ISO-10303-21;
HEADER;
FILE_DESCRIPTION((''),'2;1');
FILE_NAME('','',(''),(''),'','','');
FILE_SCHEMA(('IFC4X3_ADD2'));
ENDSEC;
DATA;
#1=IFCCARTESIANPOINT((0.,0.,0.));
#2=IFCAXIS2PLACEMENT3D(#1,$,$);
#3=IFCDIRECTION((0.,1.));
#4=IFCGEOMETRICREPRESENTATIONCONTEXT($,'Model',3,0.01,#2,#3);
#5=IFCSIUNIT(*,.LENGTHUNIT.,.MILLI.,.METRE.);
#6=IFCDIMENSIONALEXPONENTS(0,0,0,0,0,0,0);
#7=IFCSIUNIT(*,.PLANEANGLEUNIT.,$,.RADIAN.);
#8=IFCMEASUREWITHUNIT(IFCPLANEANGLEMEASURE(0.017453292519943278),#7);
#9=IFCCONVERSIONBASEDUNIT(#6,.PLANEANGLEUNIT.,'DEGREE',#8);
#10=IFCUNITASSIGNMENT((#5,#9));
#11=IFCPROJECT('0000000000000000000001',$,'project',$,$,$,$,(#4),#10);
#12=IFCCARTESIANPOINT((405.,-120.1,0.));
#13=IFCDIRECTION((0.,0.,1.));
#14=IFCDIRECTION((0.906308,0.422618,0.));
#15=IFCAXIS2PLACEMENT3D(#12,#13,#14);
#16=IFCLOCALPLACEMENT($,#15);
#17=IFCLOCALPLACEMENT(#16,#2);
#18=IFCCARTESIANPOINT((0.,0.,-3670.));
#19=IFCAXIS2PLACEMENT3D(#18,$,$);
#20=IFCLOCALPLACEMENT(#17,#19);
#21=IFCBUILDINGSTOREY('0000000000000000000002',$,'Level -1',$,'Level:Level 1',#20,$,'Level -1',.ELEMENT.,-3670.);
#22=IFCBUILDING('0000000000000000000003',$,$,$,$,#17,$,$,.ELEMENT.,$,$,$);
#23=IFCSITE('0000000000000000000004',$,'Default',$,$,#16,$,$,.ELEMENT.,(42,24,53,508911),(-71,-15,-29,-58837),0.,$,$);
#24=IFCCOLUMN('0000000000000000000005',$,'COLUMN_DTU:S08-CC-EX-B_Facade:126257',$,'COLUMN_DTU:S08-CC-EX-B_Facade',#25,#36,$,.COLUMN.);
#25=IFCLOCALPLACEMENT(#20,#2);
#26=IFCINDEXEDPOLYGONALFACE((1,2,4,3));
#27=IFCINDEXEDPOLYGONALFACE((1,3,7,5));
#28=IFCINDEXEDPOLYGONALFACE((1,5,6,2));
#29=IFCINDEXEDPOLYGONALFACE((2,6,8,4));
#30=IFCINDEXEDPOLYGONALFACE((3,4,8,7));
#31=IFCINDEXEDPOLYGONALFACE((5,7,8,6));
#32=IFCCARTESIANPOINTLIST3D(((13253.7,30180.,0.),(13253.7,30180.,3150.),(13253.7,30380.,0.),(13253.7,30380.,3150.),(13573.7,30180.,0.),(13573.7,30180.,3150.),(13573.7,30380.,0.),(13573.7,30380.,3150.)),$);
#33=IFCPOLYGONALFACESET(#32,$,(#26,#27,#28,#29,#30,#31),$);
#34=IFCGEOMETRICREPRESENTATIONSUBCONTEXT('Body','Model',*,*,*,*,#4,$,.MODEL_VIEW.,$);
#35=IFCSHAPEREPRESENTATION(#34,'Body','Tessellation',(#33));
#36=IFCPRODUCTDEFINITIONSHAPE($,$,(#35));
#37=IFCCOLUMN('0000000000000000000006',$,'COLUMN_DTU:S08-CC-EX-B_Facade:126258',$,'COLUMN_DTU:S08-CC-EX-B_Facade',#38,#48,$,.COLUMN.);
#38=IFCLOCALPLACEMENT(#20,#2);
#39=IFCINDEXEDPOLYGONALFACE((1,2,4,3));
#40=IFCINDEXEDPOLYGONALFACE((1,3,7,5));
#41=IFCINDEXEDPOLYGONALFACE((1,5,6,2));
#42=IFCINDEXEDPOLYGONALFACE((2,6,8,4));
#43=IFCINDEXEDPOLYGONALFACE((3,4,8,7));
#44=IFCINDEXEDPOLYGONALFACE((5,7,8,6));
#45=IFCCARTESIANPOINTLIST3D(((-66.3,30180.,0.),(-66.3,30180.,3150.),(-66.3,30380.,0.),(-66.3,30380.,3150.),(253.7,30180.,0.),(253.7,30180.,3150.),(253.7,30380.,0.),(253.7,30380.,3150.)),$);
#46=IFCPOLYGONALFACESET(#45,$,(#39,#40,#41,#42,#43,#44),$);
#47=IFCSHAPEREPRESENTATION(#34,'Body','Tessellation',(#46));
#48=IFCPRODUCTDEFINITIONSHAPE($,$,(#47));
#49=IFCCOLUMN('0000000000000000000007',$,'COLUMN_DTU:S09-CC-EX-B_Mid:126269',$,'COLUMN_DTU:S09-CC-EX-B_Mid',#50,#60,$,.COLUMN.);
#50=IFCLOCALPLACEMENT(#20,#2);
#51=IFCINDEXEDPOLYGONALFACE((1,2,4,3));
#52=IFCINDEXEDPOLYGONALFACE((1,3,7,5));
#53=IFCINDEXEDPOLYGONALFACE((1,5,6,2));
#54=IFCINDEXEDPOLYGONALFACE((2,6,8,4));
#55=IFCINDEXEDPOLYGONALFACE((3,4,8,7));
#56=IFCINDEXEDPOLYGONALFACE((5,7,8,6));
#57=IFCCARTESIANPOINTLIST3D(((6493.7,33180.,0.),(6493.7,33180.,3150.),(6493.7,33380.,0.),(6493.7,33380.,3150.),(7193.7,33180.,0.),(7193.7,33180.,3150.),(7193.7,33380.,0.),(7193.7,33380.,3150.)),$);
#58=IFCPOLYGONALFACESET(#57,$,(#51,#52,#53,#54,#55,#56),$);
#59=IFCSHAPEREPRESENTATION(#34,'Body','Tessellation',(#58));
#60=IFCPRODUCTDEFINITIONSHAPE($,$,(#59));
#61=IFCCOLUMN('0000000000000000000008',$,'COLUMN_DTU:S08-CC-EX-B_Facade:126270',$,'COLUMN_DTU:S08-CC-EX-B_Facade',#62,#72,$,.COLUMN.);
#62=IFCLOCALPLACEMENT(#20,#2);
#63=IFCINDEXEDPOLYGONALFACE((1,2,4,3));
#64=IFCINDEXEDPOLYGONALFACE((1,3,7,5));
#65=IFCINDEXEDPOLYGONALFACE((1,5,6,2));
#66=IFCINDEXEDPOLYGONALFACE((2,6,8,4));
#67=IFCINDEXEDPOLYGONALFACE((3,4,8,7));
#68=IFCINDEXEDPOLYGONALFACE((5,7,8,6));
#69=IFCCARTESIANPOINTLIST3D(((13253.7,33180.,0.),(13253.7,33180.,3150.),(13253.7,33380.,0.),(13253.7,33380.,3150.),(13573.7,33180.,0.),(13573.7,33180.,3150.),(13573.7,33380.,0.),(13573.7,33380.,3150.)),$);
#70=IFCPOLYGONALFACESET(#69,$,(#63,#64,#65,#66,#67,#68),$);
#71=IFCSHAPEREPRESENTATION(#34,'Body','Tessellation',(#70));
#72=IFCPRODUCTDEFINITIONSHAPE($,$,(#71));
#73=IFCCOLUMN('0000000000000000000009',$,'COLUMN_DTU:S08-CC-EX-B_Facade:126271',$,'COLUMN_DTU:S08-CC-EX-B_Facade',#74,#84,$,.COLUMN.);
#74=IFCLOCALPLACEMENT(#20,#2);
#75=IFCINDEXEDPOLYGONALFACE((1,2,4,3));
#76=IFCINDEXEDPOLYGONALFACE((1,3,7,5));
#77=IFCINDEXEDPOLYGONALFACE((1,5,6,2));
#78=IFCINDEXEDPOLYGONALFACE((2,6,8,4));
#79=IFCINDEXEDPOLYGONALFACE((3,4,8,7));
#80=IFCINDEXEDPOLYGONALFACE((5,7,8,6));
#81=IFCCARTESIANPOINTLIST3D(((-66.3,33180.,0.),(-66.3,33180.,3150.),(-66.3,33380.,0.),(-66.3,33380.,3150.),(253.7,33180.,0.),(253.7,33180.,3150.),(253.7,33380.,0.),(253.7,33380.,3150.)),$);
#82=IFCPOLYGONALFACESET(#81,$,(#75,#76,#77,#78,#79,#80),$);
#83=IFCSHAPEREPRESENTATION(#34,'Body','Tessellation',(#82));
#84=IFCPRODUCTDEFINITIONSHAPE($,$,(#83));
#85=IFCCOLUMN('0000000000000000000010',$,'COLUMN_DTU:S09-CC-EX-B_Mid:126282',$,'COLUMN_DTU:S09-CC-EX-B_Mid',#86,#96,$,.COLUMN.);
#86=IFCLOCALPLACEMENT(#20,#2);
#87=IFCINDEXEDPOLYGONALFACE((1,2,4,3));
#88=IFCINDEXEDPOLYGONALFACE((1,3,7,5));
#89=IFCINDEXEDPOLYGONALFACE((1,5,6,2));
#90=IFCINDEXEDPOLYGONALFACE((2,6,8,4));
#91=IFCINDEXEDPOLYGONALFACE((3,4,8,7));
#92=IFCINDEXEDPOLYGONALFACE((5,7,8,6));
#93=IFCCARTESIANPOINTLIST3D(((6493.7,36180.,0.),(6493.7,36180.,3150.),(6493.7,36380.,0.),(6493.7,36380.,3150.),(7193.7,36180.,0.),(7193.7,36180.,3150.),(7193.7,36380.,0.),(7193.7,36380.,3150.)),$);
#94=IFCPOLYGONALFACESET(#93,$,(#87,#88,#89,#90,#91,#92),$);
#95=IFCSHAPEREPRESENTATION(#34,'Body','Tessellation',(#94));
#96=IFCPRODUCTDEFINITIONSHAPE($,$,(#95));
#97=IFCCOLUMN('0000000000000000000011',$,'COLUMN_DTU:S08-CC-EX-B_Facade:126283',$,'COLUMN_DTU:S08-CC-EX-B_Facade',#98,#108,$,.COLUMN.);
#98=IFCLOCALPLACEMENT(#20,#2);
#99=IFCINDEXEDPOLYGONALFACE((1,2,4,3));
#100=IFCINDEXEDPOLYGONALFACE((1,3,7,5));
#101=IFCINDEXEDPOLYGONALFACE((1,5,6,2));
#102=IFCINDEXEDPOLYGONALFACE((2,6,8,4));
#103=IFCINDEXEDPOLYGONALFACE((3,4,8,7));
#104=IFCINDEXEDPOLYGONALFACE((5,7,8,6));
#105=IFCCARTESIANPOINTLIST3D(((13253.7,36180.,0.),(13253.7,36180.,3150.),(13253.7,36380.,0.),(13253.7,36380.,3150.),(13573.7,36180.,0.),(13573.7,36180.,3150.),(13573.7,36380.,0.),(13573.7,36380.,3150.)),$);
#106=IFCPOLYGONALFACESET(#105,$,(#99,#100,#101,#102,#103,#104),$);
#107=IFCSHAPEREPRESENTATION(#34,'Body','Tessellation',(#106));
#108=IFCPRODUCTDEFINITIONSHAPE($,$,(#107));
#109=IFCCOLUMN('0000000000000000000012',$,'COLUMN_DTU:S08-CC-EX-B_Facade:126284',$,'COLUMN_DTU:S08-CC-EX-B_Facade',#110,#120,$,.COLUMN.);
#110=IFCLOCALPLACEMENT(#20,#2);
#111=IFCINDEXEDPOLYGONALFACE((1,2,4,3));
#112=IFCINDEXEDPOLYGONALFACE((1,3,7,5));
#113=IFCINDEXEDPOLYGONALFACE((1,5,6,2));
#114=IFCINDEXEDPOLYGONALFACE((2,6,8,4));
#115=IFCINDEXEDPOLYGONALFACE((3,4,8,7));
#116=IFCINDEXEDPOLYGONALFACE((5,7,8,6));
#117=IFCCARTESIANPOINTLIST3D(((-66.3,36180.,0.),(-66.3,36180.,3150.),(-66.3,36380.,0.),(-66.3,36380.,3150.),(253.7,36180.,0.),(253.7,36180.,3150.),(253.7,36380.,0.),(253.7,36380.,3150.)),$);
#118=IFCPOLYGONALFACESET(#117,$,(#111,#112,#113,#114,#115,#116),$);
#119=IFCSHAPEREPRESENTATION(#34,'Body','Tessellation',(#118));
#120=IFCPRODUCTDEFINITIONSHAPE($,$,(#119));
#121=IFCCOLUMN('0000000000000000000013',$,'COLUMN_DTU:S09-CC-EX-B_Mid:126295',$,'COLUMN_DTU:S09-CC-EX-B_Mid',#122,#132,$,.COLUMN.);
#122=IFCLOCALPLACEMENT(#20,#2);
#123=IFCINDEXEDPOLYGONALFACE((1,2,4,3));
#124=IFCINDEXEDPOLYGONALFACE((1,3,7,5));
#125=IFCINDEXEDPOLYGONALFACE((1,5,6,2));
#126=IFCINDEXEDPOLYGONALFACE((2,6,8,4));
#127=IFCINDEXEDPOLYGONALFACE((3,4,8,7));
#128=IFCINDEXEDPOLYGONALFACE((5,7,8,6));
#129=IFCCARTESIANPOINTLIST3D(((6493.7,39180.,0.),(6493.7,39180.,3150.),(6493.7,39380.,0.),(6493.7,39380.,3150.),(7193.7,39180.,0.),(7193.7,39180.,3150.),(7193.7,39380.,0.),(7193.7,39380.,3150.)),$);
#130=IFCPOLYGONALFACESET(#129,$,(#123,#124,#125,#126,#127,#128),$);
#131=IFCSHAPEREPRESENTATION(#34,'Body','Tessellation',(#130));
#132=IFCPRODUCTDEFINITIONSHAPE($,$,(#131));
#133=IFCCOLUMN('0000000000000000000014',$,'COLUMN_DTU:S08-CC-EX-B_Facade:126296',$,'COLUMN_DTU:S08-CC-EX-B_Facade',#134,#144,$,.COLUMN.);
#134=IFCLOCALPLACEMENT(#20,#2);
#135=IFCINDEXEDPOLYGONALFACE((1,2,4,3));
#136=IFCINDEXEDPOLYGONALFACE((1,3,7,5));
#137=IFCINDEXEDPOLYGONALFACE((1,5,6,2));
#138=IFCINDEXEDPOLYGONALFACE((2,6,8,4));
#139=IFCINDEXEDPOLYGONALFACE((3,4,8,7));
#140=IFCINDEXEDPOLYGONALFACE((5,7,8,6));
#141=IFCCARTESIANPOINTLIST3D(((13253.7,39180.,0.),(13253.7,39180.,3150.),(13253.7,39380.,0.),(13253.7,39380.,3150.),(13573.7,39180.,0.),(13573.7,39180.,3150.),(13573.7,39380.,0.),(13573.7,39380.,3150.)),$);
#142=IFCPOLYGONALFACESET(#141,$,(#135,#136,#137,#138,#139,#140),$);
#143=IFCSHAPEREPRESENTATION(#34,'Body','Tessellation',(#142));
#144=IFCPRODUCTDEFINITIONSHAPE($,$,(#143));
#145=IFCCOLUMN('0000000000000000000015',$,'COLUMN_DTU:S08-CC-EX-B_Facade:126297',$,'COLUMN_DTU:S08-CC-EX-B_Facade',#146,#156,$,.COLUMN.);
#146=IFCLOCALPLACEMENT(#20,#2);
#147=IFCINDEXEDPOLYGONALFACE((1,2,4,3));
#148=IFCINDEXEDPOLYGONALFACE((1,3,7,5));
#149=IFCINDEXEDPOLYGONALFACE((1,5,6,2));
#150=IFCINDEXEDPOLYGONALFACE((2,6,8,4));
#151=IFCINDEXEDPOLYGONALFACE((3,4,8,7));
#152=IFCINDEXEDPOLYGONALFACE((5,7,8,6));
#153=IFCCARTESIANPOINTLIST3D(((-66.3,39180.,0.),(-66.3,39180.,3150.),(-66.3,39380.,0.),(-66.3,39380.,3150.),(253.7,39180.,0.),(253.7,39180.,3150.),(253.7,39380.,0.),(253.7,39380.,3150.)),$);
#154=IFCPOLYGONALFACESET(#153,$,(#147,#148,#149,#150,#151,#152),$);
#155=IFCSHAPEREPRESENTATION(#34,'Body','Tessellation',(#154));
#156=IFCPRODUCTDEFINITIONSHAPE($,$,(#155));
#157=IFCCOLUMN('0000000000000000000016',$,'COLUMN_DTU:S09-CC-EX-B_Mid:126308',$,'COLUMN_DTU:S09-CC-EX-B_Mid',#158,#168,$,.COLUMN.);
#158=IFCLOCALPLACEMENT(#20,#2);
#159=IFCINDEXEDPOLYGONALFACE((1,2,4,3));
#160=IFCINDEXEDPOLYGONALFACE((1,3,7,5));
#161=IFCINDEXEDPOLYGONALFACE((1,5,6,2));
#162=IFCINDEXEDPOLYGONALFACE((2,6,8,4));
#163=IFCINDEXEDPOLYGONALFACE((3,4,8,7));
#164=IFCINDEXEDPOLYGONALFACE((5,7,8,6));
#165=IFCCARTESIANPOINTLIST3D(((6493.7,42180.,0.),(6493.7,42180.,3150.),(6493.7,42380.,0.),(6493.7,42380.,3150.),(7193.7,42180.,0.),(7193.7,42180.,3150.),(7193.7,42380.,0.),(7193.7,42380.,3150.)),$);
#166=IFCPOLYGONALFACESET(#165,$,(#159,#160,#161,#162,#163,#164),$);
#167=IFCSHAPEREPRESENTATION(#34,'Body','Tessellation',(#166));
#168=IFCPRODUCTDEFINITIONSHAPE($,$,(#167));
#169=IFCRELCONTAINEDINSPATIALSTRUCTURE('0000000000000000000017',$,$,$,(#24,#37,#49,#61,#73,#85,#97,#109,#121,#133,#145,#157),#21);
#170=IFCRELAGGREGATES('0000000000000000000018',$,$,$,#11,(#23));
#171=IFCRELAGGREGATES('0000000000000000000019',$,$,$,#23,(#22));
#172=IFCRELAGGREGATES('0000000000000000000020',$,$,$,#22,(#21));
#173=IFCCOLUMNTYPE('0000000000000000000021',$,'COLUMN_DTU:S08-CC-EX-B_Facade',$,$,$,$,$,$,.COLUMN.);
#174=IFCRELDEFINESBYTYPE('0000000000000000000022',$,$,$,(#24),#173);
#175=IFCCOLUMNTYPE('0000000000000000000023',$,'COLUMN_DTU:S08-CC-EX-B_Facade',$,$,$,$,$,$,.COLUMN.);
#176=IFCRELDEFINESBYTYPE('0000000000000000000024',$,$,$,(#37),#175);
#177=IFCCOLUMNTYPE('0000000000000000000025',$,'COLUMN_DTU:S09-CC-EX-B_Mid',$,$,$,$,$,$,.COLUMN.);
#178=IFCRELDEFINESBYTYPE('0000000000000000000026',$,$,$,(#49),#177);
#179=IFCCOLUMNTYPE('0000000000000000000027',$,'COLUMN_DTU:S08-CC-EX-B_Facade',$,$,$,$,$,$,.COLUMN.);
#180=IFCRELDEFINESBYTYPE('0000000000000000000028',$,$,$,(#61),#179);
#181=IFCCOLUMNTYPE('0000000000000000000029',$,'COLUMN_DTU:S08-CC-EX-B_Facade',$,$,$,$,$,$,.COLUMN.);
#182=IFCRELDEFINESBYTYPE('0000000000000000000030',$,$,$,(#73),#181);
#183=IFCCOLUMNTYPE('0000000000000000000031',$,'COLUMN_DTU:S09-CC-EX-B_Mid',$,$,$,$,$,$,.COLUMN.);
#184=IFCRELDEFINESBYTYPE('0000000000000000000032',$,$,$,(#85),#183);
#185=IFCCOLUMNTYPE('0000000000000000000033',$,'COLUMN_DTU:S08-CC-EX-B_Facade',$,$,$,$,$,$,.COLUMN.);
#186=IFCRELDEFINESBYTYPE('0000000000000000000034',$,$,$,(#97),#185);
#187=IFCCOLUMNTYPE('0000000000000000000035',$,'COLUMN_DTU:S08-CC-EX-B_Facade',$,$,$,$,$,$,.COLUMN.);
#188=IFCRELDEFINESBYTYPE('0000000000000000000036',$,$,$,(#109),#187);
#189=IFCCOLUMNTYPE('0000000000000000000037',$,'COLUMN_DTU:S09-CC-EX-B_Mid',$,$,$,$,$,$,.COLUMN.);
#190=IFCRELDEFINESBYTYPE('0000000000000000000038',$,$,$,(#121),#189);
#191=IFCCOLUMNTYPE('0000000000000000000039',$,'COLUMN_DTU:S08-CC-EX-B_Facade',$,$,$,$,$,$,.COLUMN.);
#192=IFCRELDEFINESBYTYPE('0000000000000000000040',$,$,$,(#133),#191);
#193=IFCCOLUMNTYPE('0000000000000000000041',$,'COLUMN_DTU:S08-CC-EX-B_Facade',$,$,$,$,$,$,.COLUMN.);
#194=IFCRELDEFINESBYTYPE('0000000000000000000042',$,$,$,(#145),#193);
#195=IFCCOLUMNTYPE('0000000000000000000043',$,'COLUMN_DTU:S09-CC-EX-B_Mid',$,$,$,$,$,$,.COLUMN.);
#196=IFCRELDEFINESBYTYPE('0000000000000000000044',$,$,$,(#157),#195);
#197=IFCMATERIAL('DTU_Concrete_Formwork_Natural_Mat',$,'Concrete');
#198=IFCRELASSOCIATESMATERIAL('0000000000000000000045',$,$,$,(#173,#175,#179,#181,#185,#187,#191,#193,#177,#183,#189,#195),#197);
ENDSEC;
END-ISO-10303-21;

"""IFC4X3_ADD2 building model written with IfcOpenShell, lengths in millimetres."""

from ifc_helpers import new_model, entity, si_unit, converted_unit, direction, frame, frame_2d, origin, origin_2d_with_axis, place, context, subcontext, project, spatial, rectangle, extrude, source, transform, mapped, material, material_profile, profile_set, type_object, type_shapes, element, save


model = new_model("IFC4X3_ADD2")

# Units and contexts
model_context = context("Model", 3, precision=0.01, world=origin(), true_north=direction((0.0, 1.0)))
body_context = subcontext(model_context, "Body", "Model", "MODEL_VIEW")
ifc_project = project(units=[si_unit("LENGTHUNIT", "METRE", prefix="MILLI"), converted_unit("PLANEANGLEUNIT", "DEGREE", entity("IfcPlaneAngleMeasure", 0.017453292519943278), si_unit("PLANEANGLEUNIT", "RADIAN"), dimensions=[0, 0, 0, 0, 0, 0, 0])], contexts=[model_context])

# Site, building, storey
site_placement = place(None, frame((405.0, -120.1, 0.0), z_axis=(0.0, 0.0, 1.0), x_axis=(0.906308, 0.422618, 0.0)))
site = spatial("IfcSite", under=ifc_project, at=site_placement, Name="Default", CompositionType="ELEMENT", RefLatitude=(42, 24, 53, 508911), RefLongitude=(-71, -15, -29, -58837), RefElevation=0.0)
building_placement = place(site_placement, origin())
building = spatial("IfcBuilding", under=site, at=building_placement, CompositionType="ELEMENT")
storey_placement = place(building_placement, frame((0.0, 0.0, -3670.0)))
storey = spatial("IfcBuildingStorey", under=building, at=storey_placement, Name="Level -1", ObjectType="Level:Level 1", LongName="Level -1", CompositionType="ELEMENT", Elevation=-3670.0)

# Columns
ifc_material = material(Name="DTU_Concrete_Formwork_Natural_Mat", Category="Concrete")
ifc_material_profile_1 = material_profile(ifc_material, rectangle(XDim=200.0, YDim=320.0, at=origin_2d_with_axis()), Name="S08-CC-EX-B_Facade")
ifc_profile_set_1 = profile_set([ifc_material_profile_1], Name="S08-CC-EX-B_Facade")
column_type_1 = type_object("IfcColumnType", Name="COLUMN_DTU:S08-CC-EX-B_Facade", PredefinedType="COLUMN", material=ifc_profile_set_1)
shared_shape_1 = source(origin(), body_context, "Body", "SweptSolid", [
    extrude(rectangle(XDim=200.0, YDim=320.0, at=origin_2d_with_axis()), frame((13413.7, 30280.0, -3670.0), z_axis=(0.0, 0.0, 1.0), x_axis=(0.0, 1.0, 0.0)), (0.0, 0.0, 1.0), 3150.0),
])
type_shapes(column_type_1, [shared_shape_1])
column_1_placement = place(storey_placement, frame((0.0, 0.0, 3670.0)))
element("IfcColumn", 1, at=column_1_placement, inside=storey, type_object=column_type_1, Name="COLUMN_DTU:S08-CC-EX-B_Facade:126257", ObjectType="COLUMN_DTU:S08-CC-EX-B_Facade", PredefinedType="COLUMN", context=body_context, shape_type="MappedRepresentation", body=[
    mapped(shared_shape_1, transform((0.0, 0.0, 0.0), scale=1.0)),
])
column_type_2 = type_object("IfcColumnType", Name="COLUMN_DTU:S08-CC-EX-B_Facade", PredefinedType="COLUMN", material=ifc_profile_set_1)
shared_shape_2 = source(origin(), body_context, "Body", "SweptSolid", [
    extrude(rectangle(XDim=200.0, YDim=320.0, at=frame_2d((0.0, 0.0), x_axis=(1.0, 0.0))), frame((93.7, 30280.0, -3670.0), z_axis=(0.0, 0.0, 1.0), x_axis=(0.0, 1.0, 0.0)), (0.0, 0.0, 1.0), 3150.0),
])
type_shapes(column_type_2, [shared_shape_2])
column_2_placement = place(storey_placement, frame((0.0, 0.0, 3670.0)))
element("IfcColumn", 2, at=column_2_placement, inside=storey, type_object=column_type_2, Name="COLUMN_DTU:S08-CC-EX-B_Facade:126258", ObjectType="COLUMN_DTU:S08-CC-EX-B_Facade", PredefinedType="COLUMN", context=body_context, shape_type="MappedRepresentation", body=[
    mapped(shared_shape_2, transform((0.0, 0.0, 0.0), scale=1.0)),
])
ifc_material_profile_2 = material_profile(ifc_material, rectangle(XDim=200.0, YDim=700.0, at=frame_2d((0.0, 0.0), x_axis=(1.0, 0.0))), Name="S09-CC-EX-B_Mid")
ifc_profile_set_2 = profile_set([ifc_material_profile_2], Name="S09-CC-EX-B_Mid")
column_type_3 = type_object("IfcColumnType", Name="COLUMN_DTU:S09-CC-EX-B_Mid", PredefinedType="COLUMN", material=ifc_profile_set_2)
shared_shape_3 = source(origin(), body_context, "Body", "SweptSolid", [
    extrude(rectangle(XDim=200.0, YDim=700.0, at=frame_2d((0.0, 0.0), x_axis=(1.0, 0.0))), frame((6843.7, 33280.0, -3670.0), z_axis=(0.0, 0.0, 1.0), x_axis=(0.0, 1.0, 0.0)), (0.0, 0.0, 1.0), 3150.0),
])
type_shapes(column_type_3, [shared_shape_3])
column_3_placement = place(storey_placement, frame((0.0, 0.0, 3670.0)))
element("IfcColumn", 3, at=column_3_placement, inside=storey, type_object=column_type_3, Name="COLUMN_DTU:S09-CC-EX-B_Mid:126269", ObjectType="COLUMN_DTU:S09-CC-EX-B_Mid", PredefinedType="COLUMN", context=body_context, shape_type="MappedRepresentation", body=[
    mapped(shared_shape_3, transform((0.0, 0.0, 0.0), scale=1.0)),
])
column_type_4 = type_object("IfcColumnType", Name="COLUMN_DTU:S08-CC-EX-B_Facade", PredefinedType="COLUMN", material=ifc_profile_set_1)
shared_shape_4 = source(origin(), body_context, "Body", "SweptSolid", [
    extrude(rectangle(XDim=200.0, YDim=320.0, at=origin_2d_with_axis()), frame((13413.7, 33280.0, -3670.0), z_axis=(0.0, 0.0, 1.0), x_axis=(0.0, 1.0, 0.0)), (0.0, 0.0, 1.0), 3150.0),
])
type_shapes(column_type_4, [shared_shape_4])
column_4_placement = place(storey_placement, frame((0.0, 0.0, 3670.0)))
element("IfcColumn", 4, at=column_4_placement, inside=storey, type_object=column_type_4, Name="COLUMN_DTU:S08-CC-EX-B_Facade:126270", ObjectType="COLUMN_DTU:S08-CC-EX-B_Facade", PredefinedType="COLUMN", context=body_context, shape_type="MappedRepresentation", body=[
    mapped(shared_shape_4, transform((0.0, 0.0, 0.0), scale=1.0)),
])
column_type_5 = type_object("IfcColumnType", Name="COLUMN_DTU:S08-CC-EX-B_Facade", PredefinedType="COLUMN", material=ifc_profile_set_1)
shared_shape_5 = source(origin(), body_context, "Body", "SweptSolid", [
    extrude(rectangle(XDim=200.0, YDim=320.0, at=origin_2d_with_axis()), frame((93.7, 33280.0, -3670.0), z_axis=(0.0, 0.0, 1.0), x_axis=(0.0, 1.0, 0.0)), (0.0, 0.0, 1.0), 3150.0),
])
type_shapes(column_type_5, [shared_shape_5])
column_5_placement = place(storey_placement, frame((0.0, 0.0, 3670.0)))
element("IfcColumn", 5, at=column_5_placement, inside=storey, type_object=column_type_5, Name="COLUMN_DTU:S08-CC-EX-B_Facade:126271", ObjectType="COLUMN_DTU:S08-CC-EX-B_Facade", PredefinedType="COLUMN", context=body_context, shape_type="MappedRepresentation", body=[
    mapped(shared_shape_5, transform((0.0, 0.0, 0.0), scale=1.0)),
])
column_type_6 = type_object("IfcColumnType", Name="COLUMN_DTU:S09-CC-EX-B_Mid", PredefinedType="COLUMN", material=ifc_profile_set_2)
shared_shape_6 = source(origin(), body_context, "Body", "SweptSolid", [
    extrude(rectangle(XDim=200.0, YDim=700.0, at=frame_2d((0.0, 0.0), x_axis=(1.0, 0.0))), frame((6843.7, 36280.0, -3670.0), z_axis=(0.0, 0.0, 1.0), x_axis=(0.0, 1.0, 0.0)), (0.0, 0.0, 1.0), 3150.0),
])
type_shapes(column_type_6, [shared_shape_6])
column_6_placement = place(storey_placement, frame((0.0, 0.0, 3670.0)))
element("IfcColumn", 6, at=column_6_placement, inside=storey, type_object=column_type_6, Name="COLUMN_DTU:S09-CC-EX-B_Mid:126282", ObjectType="COLUMN_DTU:S09-CC-EX-B_Mid", PredefinedType="COLUMN", context=body_context, shape_type="MappedRepresentation", body=[
    mapped(shared_shape_6, transform((0.0, 0.0, 0.0), scale=1.0)),
])
column_type_7 = type_object("IfcColumnType", Name="COLUMN_DTU:S08-CC-EX-B_Facade", PredefinedType="COLUMN", material=ifc_profile_set_1)
shared_shape_7 = source(origin(), body_context, "Body", "SweptSolid", [
    extrude(rectangle(XDim=200.0, YDim=320.0, at=origin_2d_with_axis()), frame((13413.7, 36280.0, -3670.0), z_axis=(0.0, 0.0, 1.0), x_axis=(0.0, 1.0, 0.0)), (0.0, 0.0, 1.0), 3150.0),
])
type_shapes(column_type_7, [shared_shape_7])
column_7_placement = place(storey_placement, frame((0.0, 0.0, 3670.0)))
element("IfcColumn", 7, at=column_7_placement, inside=storey, type_object=column_type_7, Name="COLUMN_DTU:S08-CC-EX-B_Facade:126283", ObjectType="COLUMN_DTU:S08-CC-EX-B_Facade", PredefinedType="COLUMN", context=body_context, shape_type="MappedRepresentation", body=[
    mapped(shared_shape_7, transform((0.0, 0.0, 0.0), scale=1.0)),
])
column_type_8 = type_object("IfcColumnType", Name="COLUMN_DTU:S08-CC-EX-B_Facade", PredefinedType="COLUMN", material=ifc_profile_set_1)
shared_shape_8 = source(origin(), body_context, "Body", "SweptSolid", [
    extrude(rectangle(XDim=200.0, YDim=320.0, at=origin_2d_with_axis()), frame((93.7, 36280.0, -3670.0), z_axis=(0.0, 0.0, 1.0), x_axis=(0.0, 1.0, 0.0)), (0.0, 0.0, 1.0), 3150.0),
])
type_shapes(column_type_8, [shared_shape_8])
column_8_placement = place(storey_placement, frame((0.0, 0.0, 3670.0)))
element("IfcColumn", 8, at=column_8_placement, inside=storey, type_object=column_type_8, Name="COLUMN_DTU:S08-CC-EX-B_Facade:126284", ObjectType="COLUMN_DTU:S08-CC-EX-B_Facade", PredefinedType="COLUMN", context=body_context, shape_type="MappedRepresentation", body=[
    mapped(shared_shape_8, transform((0.0, 0.0, 0.0), scale=1.0)),
])
column_type_9 = type_object("IfcColumnType", Name="COLUMN_DTU:S09-CC-EX-B_Mid", PredefinedType="COLUMN", material=ifc_profile_set_2)
shared_shape_9 = source(origin(), body_context, "Body", "SweptSolid", [
    extrude(rectangle(XDim=200.0, YDim=700.0, at=frame_2d((0.0, 0.0), x_axis=(1.0, 0.0))), frame((6843.7, 39280.0, -3670.0), z_axis=(0.0, 0.0, 1.0), x_axis=(0.0, 1.0, 0.0)), (0.0, 0.0, 1.0), 3150.0),
])
type_shapes(column_type_9, [shared_shape_9])
column_9_placement = place(storey_placement, frame((0.0, 0.0, 3670.0)))
element("IfcColumn", 9, at=column_9_placement, inside=storey, type_object=column_type_9, Name="COLUMN_DTU:S09-CC-EX-B_Mid:126295", ObjectType="COLUMN_DTU:S09-CC-EX-B_Mid", PredefinedType="COLUMN", context=body_context, shape_type="MappedRepresentation", body=[
    mapped(shared_shape_9, transform((0.0, 0.0, 0.0), scale=1.0)),
])
column_type_10 = type_object("IfcColumnType", Name="COLUMN_DTU:S08-CC-EX-B_Facade", PredefinedType="COLUMN", material=ifc_profile_set_1)
shared_shape_10 = source(origin(), body_context, "Body", "SweptSolid", [
    extrude(rectangle(XDim=200.0, YDim=320.0, at=frame_2d((0.0, 0.0), x_axis=(1.0, 0.0))), frame((13413.7, 39280.0, -3670.0), z_axis=(0.0, 0.0, 1.0), x_axis=(0.0, 1.0, 0.0)), (0.0, 0.0, 1.0), 3150.0),
])
type_shapes(column_type_10, [shared_shape_10])
column_10_placement = place(storey_placement, frame((0.0, 0.0, 3670.0)))
element("IfcColumn", 10, at=column_10_placement, inside=storey, type_object=column_type_10, Name="COLUMN_DTU:S08-CC-EX-B_Facade:126296", ObjectType="COLUMN_DTU:S08-CC-EX-B_Facade", PredefinedType="COLUMN", context=body_context, shape_type="MappedRepresentation", body=[
    mapped(shared_shape_10, transform((0.0, 0.0, 0.0), scale=1.0)),
])
column_type_11 = type_object("IfcColumnType", Name="COLUMN_DTU:S08-CC-EX-B_Facade", PredefinedType="COLUMN", material=ifc_profile_set_1)
shared_shape_11 = source(origin(), body_context, "Body", "SweptSolid", [
    extrude(rectangle(XDim=200.0, YDim=320.0, at=frame_2d((0.0, 0.0), x_axis=(1.0, 0.0))), frame((93.7, 39280.0, -3670.0), z_axis=(0.0, 0.0, 1.0), x_axis=(0.0, 1.0, 0.0)), (0.0, 0.0, 1.0), 3150.0),
])
type_shapes(column_type_11, [shared_shape_11])
column_11_placement = place(storey_placement, frame((0.0, 0.0, 3670.0)))
element("IfcColumn", 11, at=column_11_placement, inside=storey, type_object=column_type_11, Name="COLUMN_DTU:S08-CC-EX-B_Facade:126297", ObjectType="COLUMN_DTU:S08-CC-EX-B_Facade", PredefinedType="COLUMN", context=body_context, shape_type="MappedRepresentation", body=[
    mapped(shared_shape_11, transform((0.0, 0.0, 0.0), scale=1.0)),
])
column_type_12 = type_object("IfcColumnType", Name="COLUMN_DTU:S09-CC-EX-B_Mid", PredefinedType="COLUMN", material=ifc_profile_set_2)
shared_shape_12 = source(origin(), body_context, "Body", "SweptSolid", [
    extrude(rectangle(XDim=200.0, YDim=700.0, at=frame_2d((0.0, 0.0), x_axis=(1.0, 0.0))), frame((6843.7, 42280.0, -3670.0), z_axis=(0.0, 0.0, 1.0), x_axis=(0.0, 1.0, 0.0)), (0.0, 0.0, 1.0), 3150.0),
])
type_shapes(column_type_12, [shared_shape_12])
column_12_placement = place(storey_placement, frame((0.0, 0.0, 3670.0)))
element("IfcColumn", 12, at=column_12_placement, inside=storey, type_object=column_type_12, Name="COLUMN_DTU:S09-CC-EX-B_Mid:126308", ObjectType="COLUMN_DTU:S09-CC-EX-B_Mid", PredefinedType="COLUMN", context=body_context, shape_type="MappedRepresentation", body=[
    mapped(shared_shape_12, transform((0.0, 0.0, 0.0), scale=1.0)),
])

save(model, "model.ifc")
